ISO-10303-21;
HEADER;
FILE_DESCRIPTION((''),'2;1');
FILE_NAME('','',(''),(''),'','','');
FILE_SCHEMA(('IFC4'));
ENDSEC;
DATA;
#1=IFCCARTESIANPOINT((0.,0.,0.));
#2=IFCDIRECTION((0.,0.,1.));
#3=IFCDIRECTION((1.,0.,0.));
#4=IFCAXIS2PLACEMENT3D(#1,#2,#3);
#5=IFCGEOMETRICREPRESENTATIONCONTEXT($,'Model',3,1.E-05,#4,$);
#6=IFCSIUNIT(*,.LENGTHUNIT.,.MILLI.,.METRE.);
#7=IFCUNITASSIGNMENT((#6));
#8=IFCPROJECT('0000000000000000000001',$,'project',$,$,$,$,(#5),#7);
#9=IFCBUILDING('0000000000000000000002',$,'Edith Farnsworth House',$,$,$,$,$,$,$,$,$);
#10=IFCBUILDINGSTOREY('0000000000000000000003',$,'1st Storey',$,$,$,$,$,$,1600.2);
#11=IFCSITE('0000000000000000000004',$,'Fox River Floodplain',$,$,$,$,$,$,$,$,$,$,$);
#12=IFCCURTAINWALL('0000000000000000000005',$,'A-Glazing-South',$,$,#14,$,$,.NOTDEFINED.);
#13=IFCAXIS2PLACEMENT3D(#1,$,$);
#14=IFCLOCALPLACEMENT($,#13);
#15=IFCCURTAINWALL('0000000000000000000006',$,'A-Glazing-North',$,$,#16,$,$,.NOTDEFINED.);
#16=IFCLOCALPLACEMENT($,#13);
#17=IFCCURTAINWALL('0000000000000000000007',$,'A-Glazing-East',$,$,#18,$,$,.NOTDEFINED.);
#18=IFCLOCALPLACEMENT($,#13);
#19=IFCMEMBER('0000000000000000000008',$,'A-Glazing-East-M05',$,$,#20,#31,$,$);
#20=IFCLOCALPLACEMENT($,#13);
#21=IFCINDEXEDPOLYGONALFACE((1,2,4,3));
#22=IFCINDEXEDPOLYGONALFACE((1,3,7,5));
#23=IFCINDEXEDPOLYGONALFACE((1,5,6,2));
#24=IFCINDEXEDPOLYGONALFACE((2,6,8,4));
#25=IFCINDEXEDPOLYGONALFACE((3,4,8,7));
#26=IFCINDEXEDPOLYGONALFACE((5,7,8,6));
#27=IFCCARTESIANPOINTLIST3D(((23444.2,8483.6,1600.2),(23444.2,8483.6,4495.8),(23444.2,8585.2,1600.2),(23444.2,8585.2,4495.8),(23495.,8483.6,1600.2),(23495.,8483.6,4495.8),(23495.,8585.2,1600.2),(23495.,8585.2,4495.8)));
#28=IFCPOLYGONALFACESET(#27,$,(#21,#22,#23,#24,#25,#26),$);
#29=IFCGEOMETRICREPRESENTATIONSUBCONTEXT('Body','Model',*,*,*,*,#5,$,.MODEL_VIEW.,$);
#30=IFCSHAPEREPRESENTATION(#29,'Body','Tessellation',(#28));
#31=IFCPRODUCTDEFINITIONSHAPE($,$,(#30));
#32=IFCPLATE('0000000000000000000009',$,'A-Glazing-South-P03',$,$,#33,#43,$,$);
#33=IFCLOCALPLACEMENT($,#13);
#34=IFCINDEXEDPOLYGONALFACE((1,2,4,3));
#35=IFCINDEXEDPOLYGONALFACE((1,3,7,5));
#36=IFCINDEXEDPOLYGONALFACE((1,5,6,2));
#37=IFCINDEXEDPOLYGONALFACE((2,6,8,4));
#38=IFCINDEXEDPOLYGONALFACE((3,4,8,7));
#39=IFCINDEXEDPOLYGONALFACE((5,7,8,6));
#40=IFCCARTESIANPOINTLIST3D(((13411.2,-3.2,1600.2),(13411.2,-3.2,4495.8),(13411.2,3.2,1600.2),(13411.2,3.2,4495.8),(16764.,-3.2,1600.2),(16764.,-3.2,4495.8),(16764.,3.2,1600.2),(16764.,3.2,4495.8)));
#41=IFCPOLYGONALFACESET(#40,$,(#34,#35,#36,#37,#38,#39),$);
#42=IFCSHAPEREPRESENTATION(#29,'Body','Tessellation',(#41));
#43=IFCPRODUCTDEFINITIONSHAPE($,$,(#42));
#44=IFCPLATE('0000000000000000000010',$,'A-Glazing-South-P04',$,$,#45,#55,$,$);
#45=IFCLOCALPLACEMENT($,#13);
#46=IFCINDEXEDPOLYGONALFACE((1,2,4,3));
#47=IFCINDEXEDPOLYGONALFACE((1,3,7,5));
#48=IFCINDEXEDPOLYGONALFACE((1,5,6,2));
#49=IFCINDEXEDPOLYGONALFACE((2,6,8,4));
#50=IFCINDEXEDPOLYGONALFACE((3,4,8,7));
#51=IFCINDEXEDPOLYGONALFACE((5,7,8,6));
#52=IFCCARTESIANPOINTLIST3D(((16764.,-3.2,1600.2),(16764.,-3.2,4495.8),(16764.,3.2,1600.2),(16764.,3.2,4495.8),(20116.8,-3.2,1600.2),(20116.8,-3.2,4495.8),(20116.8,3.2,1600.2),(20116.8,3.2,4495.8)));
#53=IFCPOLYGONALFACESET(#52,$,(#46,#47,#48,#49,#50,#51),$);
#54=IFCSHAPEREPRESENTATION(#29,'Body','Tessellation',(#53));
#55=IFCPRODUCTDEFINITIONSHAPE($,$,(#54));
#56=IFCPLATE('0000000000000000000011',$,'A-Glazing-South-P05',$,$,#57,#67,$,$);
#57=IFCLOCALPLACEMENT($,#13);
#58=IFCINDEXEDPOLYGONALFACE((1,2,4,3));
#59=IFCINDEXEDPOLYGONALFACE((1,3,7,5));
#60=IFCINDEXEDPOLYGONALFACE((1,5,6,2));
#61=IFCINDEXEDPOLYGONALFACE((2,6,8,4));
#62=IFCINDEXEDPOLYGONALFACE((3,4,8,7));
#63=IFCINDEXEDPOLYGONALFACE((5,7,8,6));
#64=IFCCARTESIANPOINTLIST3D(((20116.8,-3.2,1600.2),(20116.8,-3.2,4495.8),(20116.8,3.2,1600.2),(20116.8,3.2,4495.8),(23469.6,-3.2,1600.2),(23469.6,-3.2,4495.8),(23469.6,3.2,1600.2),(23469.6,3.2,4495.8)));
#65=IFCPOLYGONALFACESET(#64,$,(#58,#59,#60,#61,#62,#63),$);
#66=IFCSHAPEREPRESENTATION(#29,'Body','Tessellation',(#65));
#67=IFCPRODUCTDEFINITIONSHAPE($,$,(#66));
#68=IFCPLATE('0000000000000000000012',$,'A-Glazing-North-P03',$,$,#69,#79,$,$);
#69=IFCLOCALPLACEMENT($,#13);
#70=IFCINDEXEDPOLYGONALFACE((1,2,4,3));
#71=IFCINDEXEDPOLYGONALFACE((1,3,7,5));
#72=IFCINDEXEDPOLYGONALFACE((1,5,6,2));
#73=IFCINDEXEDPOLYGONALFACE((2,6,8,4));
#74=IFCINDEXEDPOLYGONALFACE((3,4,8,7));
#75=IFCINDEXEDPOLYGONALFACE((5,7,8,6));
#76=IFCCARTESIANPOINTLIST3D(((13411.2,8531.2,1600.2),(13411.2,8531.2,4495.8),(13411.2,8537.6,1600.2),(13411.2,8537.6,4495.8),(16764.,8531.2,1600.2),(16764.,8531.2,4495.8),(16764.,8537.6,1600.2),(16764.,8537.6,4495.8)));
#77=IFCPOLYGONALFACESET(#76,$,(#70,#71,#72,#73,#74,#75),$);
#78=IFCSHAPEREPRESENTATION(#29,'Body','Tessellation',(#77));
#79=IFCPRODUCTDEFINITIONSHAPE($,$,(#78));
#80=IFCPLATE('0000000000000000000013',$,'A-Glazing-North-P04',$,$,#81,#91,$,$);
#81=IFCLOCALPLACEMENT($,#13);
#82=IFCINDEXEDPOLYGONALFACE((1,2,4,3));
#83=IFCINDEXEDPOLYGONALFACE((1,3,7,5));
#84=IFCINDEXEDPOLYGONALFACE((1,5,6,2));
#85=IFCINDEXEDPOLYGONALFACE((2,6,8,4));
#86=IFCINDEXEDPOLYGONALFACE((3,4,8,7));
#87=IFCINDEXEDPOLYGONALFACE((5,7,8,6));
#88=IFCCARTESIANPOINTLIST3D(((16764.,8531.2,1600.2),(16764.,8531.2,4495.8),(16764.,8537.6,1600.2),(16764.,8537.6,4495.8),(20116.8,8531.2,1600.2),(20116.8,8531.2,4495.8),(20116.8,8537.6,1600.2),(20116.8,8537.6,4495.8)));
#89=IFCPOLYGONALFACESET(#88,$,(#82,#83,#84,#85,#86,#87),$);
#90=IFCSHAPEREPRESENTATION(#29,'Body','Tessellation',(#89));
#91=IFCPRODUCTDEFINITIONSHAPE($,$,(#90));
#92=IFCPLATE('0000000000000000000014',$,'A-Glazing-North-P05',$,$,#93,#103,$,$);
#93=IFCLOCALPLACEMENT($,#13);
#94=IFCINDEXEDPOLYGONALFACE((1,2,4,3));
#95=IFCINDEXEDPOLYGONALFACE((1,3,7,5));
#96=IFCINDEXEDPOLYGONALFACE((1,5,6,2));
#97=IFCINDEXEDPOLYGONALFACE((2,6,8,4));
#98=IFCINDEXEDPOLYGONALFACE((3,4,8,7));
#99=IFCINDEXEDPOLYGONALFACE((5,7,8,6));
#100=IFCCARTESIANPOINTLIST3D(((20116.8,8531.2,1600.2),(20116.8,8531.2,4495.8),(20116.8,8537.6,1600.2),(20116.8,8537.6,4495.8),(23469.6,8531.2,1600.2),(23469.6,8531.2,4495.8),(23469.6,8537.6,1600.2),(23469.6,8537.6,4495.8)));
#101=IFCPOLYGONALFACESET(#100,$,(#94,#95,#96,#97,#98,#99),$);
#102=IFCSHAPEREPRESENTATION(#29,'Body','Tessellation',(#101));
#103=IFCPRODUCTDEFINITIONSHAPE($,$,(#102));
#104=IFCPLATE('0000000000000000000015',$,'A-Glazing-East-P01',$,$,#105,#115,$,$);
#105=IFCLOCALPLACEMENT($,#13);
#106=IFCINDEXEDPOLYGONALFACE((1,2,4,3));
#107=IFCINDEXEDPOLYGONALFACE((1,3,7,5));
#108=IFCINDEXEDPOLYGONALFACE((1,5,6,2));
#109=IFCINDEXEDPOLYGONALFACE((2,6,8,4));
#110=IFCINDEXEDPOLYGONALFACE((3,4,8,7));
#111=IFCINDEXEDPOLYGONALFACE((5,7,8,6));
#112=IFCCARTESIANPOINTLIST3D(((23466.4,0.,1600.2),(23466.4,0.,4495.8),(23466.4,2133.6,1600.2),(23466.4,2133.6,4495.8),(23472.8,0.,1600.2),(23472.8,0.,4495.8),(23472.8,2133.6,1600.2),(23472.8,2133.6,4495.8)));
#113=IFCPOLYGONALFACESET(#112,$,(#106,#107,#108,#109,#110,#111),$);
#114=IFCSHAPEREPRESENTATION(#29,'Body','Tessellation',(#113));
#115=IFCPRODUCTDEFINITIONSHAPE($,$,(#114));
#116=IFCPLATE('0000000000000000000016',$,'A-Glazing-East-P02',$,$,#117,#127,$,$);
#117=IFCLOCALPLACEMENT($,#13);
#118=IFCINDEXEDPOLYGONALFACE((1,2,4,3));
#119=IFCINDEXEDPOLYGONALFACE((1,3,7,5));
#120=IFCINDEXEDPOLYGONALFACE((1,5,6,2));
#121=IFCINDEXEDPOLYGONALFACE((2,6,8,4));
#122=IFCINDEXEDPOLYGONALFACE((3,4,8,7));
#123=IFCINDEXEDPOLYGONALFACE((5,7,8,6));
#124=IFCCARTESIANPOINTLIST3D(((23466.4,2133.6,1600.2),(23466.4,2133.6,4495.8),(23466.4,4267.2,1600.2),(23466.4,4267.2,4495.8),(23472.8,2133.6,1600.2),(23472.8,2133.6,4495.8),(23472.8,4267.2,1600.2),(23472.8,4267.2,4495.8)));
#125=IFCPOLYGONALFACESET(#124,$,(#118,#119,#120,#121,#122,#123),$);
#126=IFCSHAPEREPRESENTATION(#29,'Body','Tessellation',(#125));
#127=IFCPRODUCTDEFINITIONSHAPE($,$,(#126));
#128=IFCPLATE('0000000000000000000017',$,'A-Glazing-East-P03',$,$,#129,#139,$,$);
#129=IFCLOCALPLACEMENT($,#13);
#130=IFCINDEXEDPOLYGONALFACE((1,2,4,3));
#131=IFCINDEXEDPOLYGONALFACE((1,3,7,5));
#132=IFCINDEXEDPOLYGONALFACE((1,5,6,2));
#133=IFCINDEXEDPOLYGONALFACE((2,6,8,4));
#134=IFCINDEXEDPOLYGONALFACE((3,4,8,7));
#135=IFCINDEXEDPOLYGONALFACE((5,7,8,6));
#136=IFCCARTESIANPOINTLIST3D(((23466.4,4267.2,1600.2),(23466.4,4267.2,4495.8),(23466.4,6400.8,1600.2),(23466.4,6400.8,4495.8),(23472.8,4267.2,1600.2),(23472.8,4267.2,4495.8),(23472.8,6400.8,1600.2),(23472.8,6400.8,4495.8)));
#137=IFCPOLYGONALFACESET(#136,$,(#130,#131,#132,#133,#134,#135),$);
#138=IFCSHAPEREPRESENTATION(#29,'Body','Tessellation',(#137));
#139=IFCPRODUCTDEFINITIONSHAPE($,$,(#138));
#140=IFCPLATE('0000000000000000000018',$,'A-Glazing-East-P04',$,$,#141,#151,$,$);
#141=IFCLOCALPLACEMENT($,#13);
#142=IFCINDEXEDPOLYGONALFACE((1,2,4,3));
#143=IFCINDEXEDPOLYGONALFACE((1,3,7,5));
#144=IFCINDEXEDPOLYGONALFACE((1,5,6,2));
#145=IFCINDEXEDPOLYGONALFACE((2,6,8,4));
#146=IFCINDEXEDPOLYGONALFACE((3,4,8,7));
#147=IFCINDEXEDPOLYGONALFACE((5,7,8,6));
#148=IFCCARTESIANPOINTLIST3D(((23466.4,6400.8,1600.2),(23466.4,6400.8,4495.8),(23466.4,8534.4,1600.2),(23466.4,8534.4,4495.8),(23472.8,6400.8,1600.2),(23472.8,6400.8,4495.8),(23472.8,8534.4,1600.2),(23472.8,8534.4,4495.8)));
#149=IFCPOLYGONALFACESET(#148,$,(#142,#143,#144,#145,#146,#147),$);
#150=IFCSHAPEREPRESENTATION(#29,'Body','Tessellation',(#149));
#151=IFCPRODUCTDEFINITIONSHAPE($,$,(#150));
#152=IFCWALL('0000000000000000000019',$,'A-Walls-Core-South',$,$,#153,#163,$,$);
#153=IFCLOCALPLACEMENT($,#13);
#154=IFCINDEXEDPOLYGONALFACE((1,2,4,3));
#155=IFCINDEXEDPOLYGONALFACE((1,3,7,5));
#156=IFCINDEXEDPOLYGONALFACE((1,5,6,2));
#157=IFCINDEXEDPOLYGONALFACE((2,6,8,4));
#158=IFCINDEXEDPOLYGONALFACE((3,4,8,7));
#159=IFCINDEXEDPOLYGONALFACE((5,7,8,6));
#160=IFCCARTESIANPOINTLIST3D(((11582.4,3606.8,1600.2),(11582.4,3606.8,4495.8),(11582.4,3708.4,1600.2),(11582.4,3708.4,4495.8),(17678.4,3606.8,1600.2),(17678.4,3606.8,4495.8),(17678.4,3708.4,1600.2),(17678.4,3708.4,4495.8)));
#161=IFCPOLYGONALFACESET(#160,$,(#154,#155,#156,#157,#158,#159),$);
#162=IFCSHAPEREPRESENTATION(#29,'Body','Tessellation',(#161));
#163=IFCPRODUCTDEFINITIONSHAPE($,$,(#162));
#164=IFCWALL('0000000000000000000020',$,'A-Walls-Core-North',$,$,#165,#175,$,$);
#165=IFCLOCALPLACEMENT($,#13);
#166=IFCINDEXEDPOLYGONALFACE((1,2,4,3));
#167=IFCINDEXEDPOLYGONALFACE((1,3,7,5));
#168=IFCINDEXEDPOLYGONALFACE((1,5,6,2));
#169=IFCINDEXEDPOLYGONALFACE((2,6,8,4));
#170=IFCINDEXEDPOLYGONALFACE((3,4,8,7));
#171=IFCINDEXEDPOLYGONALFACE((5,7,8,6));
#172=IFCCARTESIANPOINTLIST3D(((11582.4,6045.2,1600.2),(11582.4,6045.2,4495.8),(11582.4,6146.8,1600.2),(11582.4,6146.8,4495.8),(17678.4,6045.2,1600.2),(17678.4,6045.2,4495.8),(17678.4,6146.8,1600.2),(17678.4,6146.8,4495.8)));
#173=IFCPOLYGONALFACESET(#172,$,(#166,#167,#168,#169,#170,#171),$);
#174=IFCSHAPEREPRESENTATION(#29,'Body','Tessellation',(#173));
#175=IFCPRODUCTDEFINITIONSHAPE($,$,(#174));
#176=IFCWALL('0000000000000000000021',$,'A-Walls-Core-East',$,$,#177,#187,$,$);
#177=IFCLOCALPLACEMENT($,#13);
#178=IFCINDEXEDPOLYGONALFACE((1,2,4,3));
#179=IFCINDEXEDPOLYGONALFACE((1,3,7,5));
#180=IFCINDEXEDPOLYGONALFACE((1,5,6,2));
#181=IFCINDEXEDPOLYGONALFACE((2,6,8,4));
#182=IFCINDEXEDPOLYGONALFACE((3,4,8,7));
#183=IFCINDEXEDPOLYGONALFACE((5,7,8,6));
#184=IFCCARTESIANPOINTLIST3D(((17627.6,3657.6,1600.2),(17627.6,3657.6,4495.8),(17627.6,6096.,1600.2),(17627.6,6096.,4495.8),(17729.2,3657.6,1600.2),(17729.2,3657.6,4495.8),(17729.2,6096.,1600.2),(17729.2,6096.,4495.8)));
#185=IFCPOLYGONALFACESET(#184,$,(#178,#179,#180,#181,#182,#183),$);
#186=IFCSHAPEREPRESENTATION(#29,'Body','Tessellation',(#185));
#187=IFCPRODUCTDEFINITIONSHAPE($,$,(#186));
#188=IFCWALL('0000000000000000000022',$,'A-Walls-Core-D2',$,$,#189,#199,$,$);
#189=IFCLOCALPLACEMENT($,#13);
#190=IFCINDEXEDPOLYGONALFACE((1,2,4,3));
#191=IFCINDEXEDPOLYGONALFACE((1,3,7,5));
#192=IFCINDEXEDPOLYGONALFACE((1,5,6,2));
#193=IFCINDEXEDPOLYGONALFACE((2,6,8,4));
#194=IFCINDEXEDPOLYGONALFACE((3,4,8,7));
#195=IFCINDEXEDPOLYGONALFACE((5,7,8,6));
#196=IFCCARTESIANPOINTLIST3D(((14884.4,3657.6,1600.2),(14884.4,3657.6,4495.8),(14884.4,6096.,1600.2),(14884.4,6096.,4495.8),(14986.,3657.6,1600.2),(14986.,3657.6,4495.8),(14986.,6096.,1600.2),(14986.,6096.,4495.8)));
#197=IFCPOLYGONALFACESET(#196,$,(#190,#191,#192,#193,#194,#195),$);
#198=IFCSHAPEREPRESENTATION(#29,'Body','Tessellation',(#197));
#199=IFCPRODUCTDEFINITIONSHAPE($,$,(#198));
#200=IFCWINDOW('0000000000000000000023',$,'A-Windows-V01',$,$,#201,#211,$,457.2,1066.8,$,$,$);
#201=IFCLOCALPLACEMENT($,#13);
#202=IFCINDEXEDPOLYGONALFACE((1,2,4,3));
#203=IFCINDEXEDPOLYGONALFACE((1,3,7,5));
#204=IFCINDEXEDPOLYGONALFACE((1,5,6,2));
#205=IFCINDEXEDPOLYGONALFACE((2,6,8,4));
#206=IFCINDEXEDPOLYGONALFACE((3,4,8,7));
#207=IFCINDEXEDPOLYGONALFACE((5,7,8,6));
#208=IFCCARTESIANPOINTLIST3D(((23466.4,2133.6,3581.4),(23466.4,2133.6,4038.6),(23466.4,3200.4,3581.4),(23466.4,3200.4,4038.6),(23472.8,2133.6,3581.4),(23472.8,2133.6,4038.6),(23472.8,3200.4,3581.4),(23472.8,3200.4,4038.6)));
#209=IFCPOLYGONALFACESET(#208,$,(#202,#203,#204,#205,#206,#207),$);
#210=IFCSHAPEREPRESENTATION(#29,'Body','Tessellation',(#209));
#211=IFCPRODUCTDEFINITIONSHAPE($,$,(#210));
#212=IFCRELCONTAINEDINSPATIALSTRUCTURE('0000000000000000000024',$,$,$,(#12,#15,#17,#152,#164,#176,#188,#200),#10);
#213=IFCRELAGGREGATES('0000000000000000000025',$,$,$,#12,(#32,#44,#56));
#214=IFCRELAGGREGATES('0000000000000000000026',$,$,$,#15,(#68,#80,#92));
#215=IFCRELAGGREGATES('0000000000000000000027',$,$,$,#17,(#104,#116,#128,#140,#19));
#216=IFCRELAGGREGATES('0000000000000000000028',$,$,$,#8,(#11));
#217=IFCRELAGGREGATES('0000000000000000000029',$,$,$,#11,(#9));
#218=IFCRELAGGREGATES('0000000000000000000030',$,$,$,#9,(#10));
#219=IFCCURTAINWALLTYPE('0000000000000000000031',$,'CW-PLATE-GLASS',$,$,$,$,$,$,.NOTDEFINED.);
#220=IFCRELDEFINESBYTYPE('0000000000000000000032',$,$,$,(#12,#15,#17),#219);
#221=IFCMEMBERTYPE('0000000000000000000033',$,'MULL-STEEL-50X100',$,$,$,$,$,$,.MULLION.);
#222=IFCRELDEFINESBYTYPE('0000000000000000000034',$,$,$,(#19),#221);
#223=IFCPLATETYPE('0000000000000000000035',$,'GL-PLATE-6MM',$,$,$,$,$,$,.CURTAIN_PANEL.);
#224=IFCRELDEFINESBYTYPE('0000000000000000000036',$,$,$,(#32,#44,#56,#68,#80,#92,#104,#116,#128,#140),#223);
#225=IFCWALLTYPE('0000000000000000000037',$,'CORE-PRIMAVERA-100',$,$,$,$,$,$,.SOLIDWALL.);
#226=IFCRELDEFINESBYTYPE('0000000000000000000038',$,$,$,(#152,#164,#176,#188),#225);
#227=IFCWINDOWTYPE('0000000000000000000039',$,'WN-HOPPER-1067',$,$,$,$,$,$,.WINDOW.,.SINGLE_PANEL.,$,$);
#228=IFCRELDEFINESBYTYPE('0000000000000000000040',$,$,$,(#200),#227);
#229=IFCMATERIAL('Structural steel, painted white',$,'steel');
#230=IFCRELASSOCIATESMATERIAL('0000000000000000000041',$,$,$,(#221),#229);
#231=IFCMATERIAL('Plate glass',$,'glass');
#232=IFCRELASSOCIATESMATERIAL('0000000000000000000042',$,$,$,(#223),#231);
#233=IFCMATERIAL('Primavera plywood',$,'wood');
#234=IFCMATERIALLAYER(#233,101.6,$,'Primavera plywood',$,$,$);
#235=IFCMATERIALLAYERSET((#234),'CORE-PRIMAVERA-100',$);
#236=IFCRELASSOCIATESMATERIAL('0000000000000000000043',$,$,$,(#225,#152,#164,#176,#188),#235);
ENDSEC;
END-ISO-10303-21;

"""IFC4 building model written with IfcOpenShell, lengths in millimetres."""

from ifc_helpers import new_model, si_unit, frame, origin, origin_with_axes, place, context, subcontext, project, spatial, rectangle, extrude, material, layer, layer_set, layer_usage, type_object, element, aggregate, save


model = new_model("IFC4")

# Units and contexts
model_context = context("Model", 3, precision=1e-05, world=origin_with_axes())
body_context = subcontext(model_context, "Body", "Model", "MODEL_VIEW")
ifc_project = project(units=[si_unit("LENGTHUNIT", "METRE", prefix="MILLI")], contexts=[model_context])

# Site, building, storey
site = spatial("IfcSite", under=ifc_project, Name="Fox River Floodplain")
building = spatial("IfcBuilding", under=site, Name="Edith Farnsworth House")
storey = spatial("IfcBuildingStorey", under=building, Name="1st Storey", Elevation=1600.2)

# Shared definitions
ifc_material_1 = material(Name="Structural steel, painted white", Category="steel")

# Curtain walls, member
curtain_wall_type = type_object("IfcCurtainWallType", Name="CW-PLATE-GLASS", PredefinedType="NOTDEFINED")
curtain_wall_1 = element("IfcCurtainWall", 1, inside=storey, type_object=curtain_wall_type, Name="A-Glazing-South", PredefinedType="NOTDEFINED")
member_type = type_object("IfcMemberType", Name="MULL-STEEL-50X100", PredefinedType="MULLION", material=ifc_material_1)
curtain_wall_2 = element("IfcCurtainWall", 2, inside=storey, type_object=curtain_wall_type, Name="A-Glazing-North", PredefinedType="NOTDEFINED")
curtain_wall_3 = element("IfcCurtainWall", 3, inside=storey, type_object=curtain_wall_type, Name="A-Glazing-East", PredefinedType="NOTDEFINED")
member_1_placement = place(None, frame((23469.6, 8534.4, 1600.2), z_axis=(0.0, 0.0, 1.0), x_axis=(1.0, 0.0, 0.0)))
member_1 = element("IfcMember", 4, at=member_1_placement, type_object=member_type, Name="A-Glazing-East-M05", context=body_context, shape_type="SweptSolid", body=[
    extrude(rectangle(XDim=50.8, YDim=101.6), origin(), (0.0, 0.0, 1.0), 2895.6),
])

# Plates
ifc_material_2 = material(Name="Plate glass", Category="glass")
plate_type = type_object("IfcPlateType", Name="GL-PLATE-6MM", PredefinedType="CURTAIN_PANEL", material=ifc_material_2)
plate_1_placement = place(None, frame((15087.6, 0.0, 1600.2), z_axis=(0.0, 0.0, 1.0), x_axis=(1.0, 0.0, 0.0)))
plate_1 = element("IfcPlate", 5, at=plate_1_placement, type_object=plate_type, Name="A-Glazing-South-P03", context=body_context, shape_type="SweptSolid", body=[
    extrude(rectangle(XDim=3352.8, YDim=6.3), origin(), (0.0, 0.0, 1.0), 2895.6),
])
plate_2_placement = place(None, frame((18440.4, 0.0, 1600.2), z_axis=(0.0, 0.0, 1.0), x_axis=(1.0, 0.0, 0.0)))
plate_2 = element("IfcPlate", 6, at=plate_2_placement, type_object=plate_type, Name="A-Glazing-South-P04", context=body_context, shape_type="SweptSolid", body=[
    extrude(rectangle(XDim=3352.8, YDim=6.3), origin(), (0.0, 0.0, 1.0), 2895.6),
])
plate_3_placement = place(None, frame((21793.2, 0.0, 1600.2), z_axis=(0.0, 0.0, 1.0), x_axis=(1.0, 0.0, 0.0)))
plate_3 = element("IfcPlate", 7, at=plate_3_placement, type_object=plate_type, Name="A-Glazing-South-P05", context=body_context, shape_type="SweptSolid", body=[
    extrude(rectangle(XDim=3352.8, YDim=6.3), origin(), (0.0, 0.0, 1.0), 2895.6),
])
aggregate(curtain_wall_1, [plate_1, plate_2, plate_3])
plate_4_placement = place(None, frame((15087.6, 8534.4, 1600.2), z_axis=(0.0, 0.0, 1.0), x_axis=(1.0, 0.0, 0.0)))
plate_4 = element("IfcPlate", 8, at=plate_4_placement, type_object=plate_type, Name="A-Glazing-North-P03", context=body_context, shape_type="SweptSolid", body=[
    extrude(rectangle(XDim=3352.8, YDim=6.3), origin(), (0.0, 0.0, 1.0), 2895.6),
])
plate_5_placement = place(None, frame((18440.4, 8534.4, 1600.2), z_axis=(0.0, 0.0, 1.0), x_axis=(1.0, 0.0, 0.0)))
plate_5 = element("IfcPlate", 9, at=plate_5_placement, type_object=plate_type, Name="A-Glazing-North-P04", context=body_context, shape_type="SweptSolid", body=[
    extrude(rectangle(XDim=3352.8, YDim=6.3), origin(), (0.0, 0.0, 1.0), 2895.6),
])
plate_6_placement = place(None, frame((21793.2, 8534.4, 1600.2), z_axis=(0.0, 0.0, 1.0), x_axis=(1.0, 0.0, 0.0)))
plate_6 = element("IfcPlate", 10, at=plate_6_placement, type_object=plate_type, Name="A-Glazing-North-P05", context=body_context, shape_type="SweptSolid", body=[
    extrude(rectangle(XDim=3352.8, YDim=6.3), origin(), (0.0, 0.0, 1.0), 2895.6),
])
aggregate(curtain_wall_2, [plate_4, plate_5, plate_6])
plate_7_placement = place(None, frame((23469.6, 1066.8, 1600.2), z_axis=(0.0, 0.0, 1.0), x_axis=(0.0, 1.0, 0.0)))
plate_7 = element("IfcPlate", 11, at=plate_7_placement, type_object=plate_type, Name="A-Glazing-East-P01", context=body_context, shape_type="SweptSolid", body=[
    extrude(rectangle(XDim=2133.6, YDim=6.3), origin(), (0.0, 0.0, 1.0), 2895.6),
])
plate_8_placement = place(None, frame((23469.6, 3200.4, 1600.2), z_axis=(0.0, 0.0, 1.0), x_axis=(0.0, 1.0, 0.0)))
plate_8 = element("IfcPlate", 12, at=plate_8_placement, type_object=plate_type, Name="A-Glazing-East-P02", context=body_context, shape_type="SweptSolid", body=[
    extrude(rectangle(XDim=2133.6, YDim=6.3), origin(), (0.0, 0.0, 1.0), 2895.6),
])
plate_9_placement = place(None, frame((23469.6, 5334.0, 1600.2), z_axis=(0.0, 0.0, 1.0), x_axis=(0.0, 1.0, 0.0)))
plate_9 = element("IfcPlate", 13, at=plate_9_placement, type_object=plate_type, Name="A-Glazing-East-P03", context=body_context, shape_type="SweptSolid", body=[
    extrude(rectangle(XDim=2133.6, YDim=6.3), origin(), (0.0, 0.0, 1.0), 2895.6),
])
plate_10_placement = place(None, frame((23469.6, 7467.6, 1600.2), z_axis=(0.0, 0.0, 1.0), x_axis=(0.0, 1.0, 0.0)))
plate_10 = element("IfcPlate", 14, at=plate_10_placement, type_object=plate_type, Name="A-Glazing-East-P04", context=body_context, shape_type="SweptSolid", body=[
    extrude(rectangle(XDim=2133.6, YDim=6.3), origin(), (0.0, 0.0, 1.0), 2895.6),
])
aggregate(curtain_wall_3, [plate_7, plate_8, plate_9, plate_10, member_1])

# Walls
ifc_material_3 = material(Name="Primavera plywood", Category="wood")
ifc_layer = layer(ifc_material_3, 101.6, Name="Primavera plywood")
ifc_layer_set = layer_set([ifc_layer], Name="CORE-PRIMAVERA-100")
ifc_layer_usage_1 = layer_usage(ifc_layer_set, "AXIS2", "POSITIVE", 0.0)
wall_type = type_object("IfcWallType", Name="CORE-PRIMAVERA-100", PredefinedType="SOLIDWALL", material=ifc_layer_set)
wall_1_placement = place(None, frame((14630.4, 3657.6, 1600.2), z_axis=(0.0, 0.0, 1.0), x_axis=(1.0, 0.0, 0.0)))
element("IfcWall", 15, at=wall_1_placement, inside=storey, type_object=wall_type, material=ifc_layer_usage_1, Name="A-Walls-Core-South", context=body_context, shape_type="SweptSolid", body=[
    extrude(rectangle(XDim=6096.0, YDim=101.6), origin(), (0.0, 0.0, 1.0), 2895.6),
])
ifc_layer_usage_2 = layer_usage(ifc_layer_set, "AXIS2", "POSITIVE", 0.0)
wall_2_placement = place(None, frame((14630.4, 6096.0, 1600.2), z_axis=(0.0, 0.0, 1.0), x_axis=(1.0, 0.0, 0.0)))
element("IfcWall", 16, at=wall_2_placement, inside=storey, type_object=wall_type, material=ifc_layer_usage_2, Name="A-Walls-Core-North", context=body_context, shape_type="SweptSolid", body=[
    extrude(rectangle(XDim=6096.0, YDim=101.6), origin(), (0.0, 0.0, 1.0), 2895.6),
])
ifc_layer_usage_3 = layer_usage(ifc_layer_set, "AXIS2", "POSITIVE", 0.0)
wall_3_placement = place(None, frame((17678.4, 4876.8, 1600.2), z_axis=(0.0, 0.0, 1.0), x_axis=(0.0, 1.0, 0.0)))
element("IfcWall", 17, at=wall_3_placement, inside=storey, type_object=wall_type, material=ifc_layer_usage_3, Name="A-Walls-Core-East", context=body_context, shape_type="SweptSolid", body=[
    extrude(rectangle(XDim=2438.4, YDim=101.6), origin(), (0.0, 0.0, 1.0), 2895.6),
])
ifc_layer_usage_4 = layer_usage(ifc_layer_set, "AXIS2", "POSITIVE", 0.0)
wall_4_placement = place(None, frame((14935.2, 4876.8, 1600.2), z_axis=(0.0, 0.0, 1.0), x_axis=(0.0, 1.0, 0.0)))
element("IfcWall", 18, at=wall_4_placement, inside=storey, type_object=wall_type, material=ifc_layer_usage_4, Name="A-Walls-Core-D2", context=body_context, shape_type="SweptSolid", body=[
    extrude(rectangle(XDim=2438.4, YDim=101.6), origin(), (0.0, 0.0, 1.0), 2895.6),
])

# Window
window_type = type_object("IfcWindowType", Name="WN-HOPPER-1067", PartitioningType="SINGLE_PANEL", PredefinedType="WINDOW")
window_1_placement = place(None, frame((23469.6, 2667.0, 3581.4), z_axis=(0.0, 0.0, 1.0), x_axis=(0.0, 1.0, 0.0)))
element("IfcWindow", 19, at=window_1_placement, inside=storey, type_object=window_type, Name="A-Windows-V01", OverallHeight=457.2, OverallWidth=1066.8, context=body_context, shape_type="SweptSolid", body=[
    extrude(rectangle(XDim=1066.8, YDim=6.3), origin(), (0.0, 0.0, 1.0), 457.2),
])

save(model, "model.ifc")
